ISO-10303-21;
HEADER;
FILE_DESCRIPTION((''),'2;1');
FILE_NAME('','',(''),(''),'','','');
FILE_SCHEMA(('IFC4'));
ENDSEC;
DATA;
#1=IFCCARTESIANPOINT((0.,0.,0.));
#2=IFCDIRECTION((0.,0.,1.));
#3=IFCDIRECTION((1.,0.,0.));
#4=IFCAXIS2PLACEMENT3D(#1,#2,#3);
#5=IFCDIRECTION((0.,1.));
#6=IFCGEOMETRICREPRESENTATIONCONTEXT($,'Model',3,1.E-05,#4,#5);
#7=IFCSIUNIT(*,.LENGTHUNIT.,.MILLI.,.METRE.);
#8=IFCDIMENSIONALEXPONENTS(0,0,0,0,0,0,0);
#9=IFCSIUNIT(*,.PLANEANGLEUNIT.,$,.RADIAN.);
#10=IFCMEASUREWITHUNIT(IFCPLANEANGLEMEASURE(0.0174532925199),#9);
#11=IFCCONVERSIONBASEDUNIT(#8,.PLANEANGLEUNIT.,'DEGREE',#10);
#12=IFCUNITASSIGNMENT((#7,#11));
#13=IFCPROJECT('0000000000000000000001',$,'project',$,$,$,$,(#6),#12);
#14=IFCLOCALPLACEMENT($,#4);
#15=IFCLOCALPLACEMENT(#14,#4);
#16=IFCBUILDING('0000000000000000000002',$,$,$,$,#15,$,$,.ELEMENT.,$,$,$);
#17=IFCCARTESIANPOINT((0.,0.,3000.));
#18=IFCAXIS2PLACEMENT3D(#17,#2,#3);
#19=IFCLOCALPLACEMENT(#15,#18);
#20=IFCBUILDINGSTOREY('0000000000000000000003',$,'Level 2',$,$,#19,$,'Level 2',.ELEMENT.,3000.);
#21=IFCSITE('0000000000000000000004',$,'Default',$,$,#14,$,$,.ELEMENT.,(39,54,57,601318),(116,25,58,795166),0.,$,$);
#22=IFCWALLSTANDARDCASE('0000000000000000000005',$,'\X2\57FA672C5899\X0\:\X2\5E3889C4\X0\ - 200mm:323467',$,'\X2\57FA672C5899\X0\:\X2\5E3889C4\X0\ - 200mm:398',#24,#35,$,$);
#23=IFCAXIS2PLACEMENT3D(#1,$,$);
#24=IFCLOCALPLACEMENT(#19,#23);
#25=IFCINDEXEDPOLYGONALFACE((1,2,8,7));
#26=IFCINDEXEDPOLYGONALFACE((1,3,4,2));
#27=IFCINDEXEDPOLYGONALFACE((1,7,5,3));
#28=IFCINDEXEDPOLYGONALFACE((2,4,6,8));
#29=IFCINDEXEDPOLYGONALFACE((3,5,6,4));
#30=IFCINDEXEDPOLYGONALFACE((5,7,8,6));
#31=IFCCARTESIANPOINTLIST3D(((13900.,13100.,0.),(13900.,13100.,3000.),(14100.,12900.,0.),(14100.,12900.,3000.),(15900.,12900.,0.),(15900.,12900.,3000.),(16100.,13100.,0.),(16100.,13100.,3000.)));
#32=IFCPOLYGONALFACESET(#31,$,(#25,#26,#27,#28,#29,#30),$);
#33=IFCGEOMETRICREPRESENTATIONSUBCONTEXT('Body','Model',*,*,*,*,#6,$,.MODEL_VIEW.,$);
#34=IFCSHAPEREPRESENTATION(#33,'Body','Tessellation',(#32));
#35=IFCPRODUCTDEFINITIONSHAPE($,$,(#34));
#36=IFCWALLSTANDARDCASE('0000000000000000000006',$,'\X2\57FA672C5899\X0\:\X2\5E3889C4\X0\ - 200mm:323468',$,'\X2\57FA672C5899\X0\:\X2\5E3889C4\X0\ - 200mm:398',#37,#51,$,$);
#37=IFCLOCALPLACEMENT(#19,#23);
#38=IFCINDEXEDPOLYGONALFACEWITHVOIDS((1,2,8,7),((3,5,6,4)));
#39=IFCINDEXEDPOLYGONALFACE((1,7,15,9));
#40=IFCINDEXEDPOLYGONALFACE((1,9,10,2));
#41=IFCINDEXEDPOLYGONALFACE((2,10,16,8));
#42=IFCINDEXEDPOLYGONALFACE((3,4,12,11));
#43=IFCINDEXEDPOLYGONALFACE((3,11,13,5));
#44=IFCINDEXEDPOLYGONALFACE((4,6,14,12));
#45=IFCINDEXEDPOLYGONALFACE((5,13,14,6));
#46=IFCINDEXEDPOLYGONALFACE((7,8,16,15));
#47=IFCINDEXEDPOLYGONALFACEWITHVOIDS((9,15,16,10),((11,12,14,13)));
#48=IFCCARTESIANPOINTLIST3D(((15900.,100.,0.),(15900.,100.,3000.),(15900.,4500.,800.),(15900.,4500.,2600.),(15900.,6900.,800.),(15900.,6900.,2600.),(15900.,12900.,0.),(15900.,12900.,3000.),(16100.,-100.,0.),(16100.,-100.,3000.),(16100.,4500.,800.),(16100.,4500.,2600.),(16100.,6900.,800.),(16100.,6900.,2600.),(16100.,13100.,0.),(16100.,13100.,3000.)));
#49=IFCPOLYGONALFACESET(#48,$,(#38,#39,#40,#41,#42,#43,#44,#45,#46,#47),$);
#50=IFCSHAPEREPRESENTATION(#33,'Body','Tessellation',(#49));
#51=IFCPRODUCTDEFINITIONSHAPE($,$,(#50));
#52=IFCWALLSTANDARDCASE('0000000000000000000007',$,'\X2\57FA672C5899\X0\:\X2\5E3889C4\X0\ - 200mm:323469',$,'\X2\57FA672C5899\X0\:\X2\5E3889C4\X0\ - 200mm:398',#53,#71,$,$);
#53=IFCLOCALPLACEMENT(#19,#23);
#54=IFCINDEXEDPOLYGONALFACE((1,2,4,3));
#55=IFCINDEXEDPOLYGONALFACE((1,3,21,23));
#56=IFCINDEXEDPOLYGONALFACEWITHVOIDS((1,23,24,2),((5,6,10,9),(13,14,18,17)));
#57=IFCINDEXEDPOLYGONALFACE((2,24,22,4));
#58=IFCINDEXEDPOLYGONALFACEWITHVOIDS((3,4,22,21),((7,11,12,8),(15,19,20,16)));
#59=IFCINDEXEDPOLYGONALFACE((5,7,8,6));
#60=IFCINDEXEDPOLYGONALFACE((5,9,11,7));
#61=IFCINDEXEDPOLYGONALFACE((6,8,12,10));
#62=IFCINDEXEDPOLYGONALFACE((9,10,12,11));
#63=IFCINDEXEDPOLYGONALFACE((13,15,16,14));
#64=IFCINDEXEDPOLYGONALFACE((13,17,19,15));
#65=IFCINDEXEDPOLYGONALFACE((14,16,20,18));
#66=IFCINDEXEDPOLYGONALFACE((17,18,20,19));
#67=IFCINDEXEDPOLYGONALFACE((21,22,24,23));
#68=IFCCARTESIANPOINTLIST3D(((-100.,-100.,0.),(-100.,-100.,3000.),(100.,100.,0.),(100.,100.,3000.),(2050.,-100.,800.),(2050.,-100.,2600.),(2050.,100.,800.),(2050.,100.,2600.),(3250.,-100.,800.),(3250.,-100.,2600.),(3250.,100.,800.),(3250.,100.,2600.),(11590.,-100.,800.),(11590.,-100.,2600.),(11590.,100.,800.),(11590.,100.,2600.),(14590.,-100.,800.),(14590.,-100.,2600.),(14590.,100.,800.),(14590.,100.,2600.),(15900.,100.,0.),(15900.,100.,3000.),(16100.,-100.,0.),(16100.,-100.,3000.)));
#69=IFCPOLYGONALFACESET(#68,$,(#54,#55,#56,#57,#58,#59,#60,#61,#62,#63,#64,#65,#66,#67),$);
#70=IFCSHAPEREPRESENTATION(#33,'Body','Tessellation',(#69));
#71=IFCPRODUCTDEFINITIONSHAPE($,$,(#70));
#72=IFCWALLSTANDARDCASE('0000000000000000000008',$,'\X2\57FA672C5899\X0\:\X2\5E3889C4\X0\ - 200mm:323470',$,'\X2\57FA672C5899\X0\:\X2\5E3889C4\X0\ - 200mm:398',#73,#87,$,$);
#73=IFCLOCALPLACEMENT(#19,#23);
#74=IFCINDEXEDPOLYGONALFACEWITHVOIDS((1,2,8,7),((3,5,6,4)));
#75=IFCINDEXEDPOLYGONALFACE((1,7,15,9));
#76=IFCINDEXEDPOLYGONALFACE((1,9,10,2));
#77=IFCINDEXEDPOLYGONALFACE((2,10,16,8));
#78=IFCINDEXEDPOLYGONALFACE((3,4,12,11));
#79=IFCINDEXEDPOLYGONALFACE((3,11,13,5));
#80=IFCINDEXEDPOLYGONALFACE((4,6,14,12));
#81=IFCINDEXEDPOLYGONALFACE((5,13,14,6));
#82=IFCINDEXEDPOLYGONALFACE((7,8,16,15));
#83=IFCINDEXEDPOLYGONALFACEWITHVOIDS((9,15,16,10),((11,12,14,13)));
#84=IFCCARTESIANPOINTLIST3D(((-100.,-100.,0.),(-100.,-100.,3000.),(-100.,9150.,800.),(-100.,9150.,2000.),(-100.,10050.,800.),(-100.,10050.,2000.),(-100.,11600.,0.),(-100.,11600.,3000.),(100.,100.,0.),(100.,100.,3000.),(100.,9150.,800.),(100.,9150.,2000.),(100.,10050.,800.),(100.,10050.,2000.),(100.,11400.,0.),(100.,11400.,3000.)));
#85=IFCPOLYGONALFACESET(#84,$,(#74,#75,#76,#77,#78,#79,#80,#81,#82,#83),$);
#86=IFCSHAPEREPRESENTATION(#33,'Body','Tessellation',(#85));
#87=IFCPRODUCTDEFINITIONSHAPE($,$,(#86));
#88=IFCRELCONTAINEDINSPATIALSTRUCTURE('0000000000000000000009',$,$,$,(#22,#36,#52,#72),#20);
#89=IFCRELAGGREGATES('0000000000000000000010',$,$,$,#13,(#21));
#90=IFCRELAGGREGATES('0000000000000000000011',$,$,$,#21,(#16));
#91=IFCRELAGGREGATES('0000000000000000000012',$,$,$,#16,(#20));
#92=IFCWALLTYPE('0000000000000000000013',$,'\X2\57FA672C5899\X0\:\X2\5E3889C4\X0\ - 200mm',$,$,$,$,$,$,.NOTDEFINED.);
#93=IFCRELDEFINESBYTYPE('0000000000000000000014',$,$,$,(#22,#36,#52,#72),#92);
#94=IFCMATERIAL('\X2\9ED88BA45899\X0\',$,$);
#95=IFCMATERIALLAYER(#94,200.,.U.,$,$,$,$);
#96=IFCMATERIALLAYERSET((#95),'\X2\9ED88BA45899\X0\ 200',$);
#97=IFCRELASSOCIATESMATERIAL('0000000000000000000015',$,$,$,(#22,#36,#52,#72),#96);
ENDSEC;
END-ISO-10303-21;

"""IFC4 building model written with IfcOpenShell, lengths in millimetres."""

from ifc_helpers import new_model, entity, si_unit, converted_unit, direction, frame, origin_with_axes, place, context, subcontext, project, spatial, polyline, outline, extrude, material, layer, layer_set, layer_usage, type_object, element, save


model = new_model("IFC4")

# Units and contexts
model_context = context("Model", 3, precision=1e-05, world=origin_with_axes(), true_north=direction((0.0, 1.0)))
body_context = subcontext(model_context, "Body", "Model", "MODEL_VIEW")
ifc_project = project(units=[si_unit("LENGTHUNIT", "METRE", prefix="MILLI"), converted_unit("PLANEANGLEUNIT", "DEGREE", entity("IfcPlaneAngleMeasure", 0.0174532925199), si_unit("PLANEANGLEUNIT", "RADIAN"), dimensions=[0, 0, 0, 0, 0, 0, 0])], contexts=[model_context])

# Site, building, storey
site_placement = place(None, origin_with_axes())
site = spatial("IfcSite", under=ifc_project, at=site_placement, Name="Default", CompositionType="ELEMENT", RefLatitude=(39, 54, 57, 601318), RefLongitude=(116, 25, 58, 795166), RefElevation=0.0)
building_placement = place(site_placement, origin_with_axes())
building = spatial("IfcBuilding", under=site, at=building_placement, CompositionType="ELEMENT")
storey_placement = place(building_placement, frame((0.0, 0.0, 3000.0), z_axis=(0.0, 0.0, 1.0), x_axis=(1.0, 0.0, 0.0)))
storey = spatial("IfcBuildingStorey", under=building, at=storey_placement, Name="Level 2", LongName="Level 2", CompositionType="ELEMENT", Elevation=3000.0)

# Shared definitions
ifc_material_1 = material(Name="默认墙")
ifc_layer_1 = layer(ifc_material_1, 200.0, ventilated="UNKNOWN")
ifc_layer_set_1 = layer_set([ifc_layer_1], Name="默认墙 200")
wall_type = type_object("IfcWallType", Name="基本墙:常规 - 200mm", PredefinedType="NOTDEFINED")

# Wall
ifc_layer_usage_1 = layer_usage(ifc_layer_set_1, "AXIS2", "POSITIVE", -100.0)
wall_1_placement = place(storey_placement, frame((14000.0, 13000.0, 0.0), z_axis=(0.0, 0.0, 1.0), x_axis=(1.0, 0.0, 0.0)))
element("IfcWallStandardCase", 1, at=wall_1_placement, inside=storey, type_object=wall_type, material=ifc_layer_usage_1, Name="基本墙:常规 - 200mm:323467", ObjectType="基本墙:常规 - 200mm:398", context=body_context, shape_type="SweptSolid", body=[
    extrude(outline(polyline([(100.0, -100.0), (1900.0, -100.0), (2100.0, 100.0), (-100.0, 100.0), (100.0, -100.0)])), origin_with_axes(), (0.0, 0.0, 1.0), 3000.0),
])

# Wall, opening
ifc_layer_usage_2 = layer_usage(ifc_layer_set_1, "AXIS2", "POSITIVE", -100.0)
wall_2_placement = place(storey_placement, frame((16000.0, 13000.0, 0.0), z_axis=(0.0, 0.0, 1.0), x_axis=(0.0, -1.0, 0.0)))
wall_2 = element("IfcWallStandardCase", 2, at=wall_2_placement, inside=storey, type_object=wall_type, material=ifc_layer_usage_2, Name="基本墙:常规 - 200mm:323468", ObjectType="基本墙:常规 - 200mm:398", context=body_context, shape_type="SweptSolid", body=[
    extrude(outline(polyline([(100.0, -100.0), (12900.0, -100.0), (13100.0, 100.0), (-100.0, 100.0), (100.0, -100.0)])), origin_with_axes(), (0.0, 0.0, 1.0), 3000.0),
])
opening_1_placement = place(wall_2_placement, frame((7300.0, 0.0, 800.0), z_axis=(0.0, 0.0, 1.0), x_axis=(1.0, 0.0, 0.0)))
element("IfcOpeningElement", 3, at=opening_1_placement, cuts=wall_2, context=body_context, shape_type="SweptSolid", body=[
    extrude(outline(polyline([(-1200.0, 0.0), (-1200.0, -1800.0), (1200.0, -1800.0), (1200.0, 0.0), (-1200.0, 0.0)])), frame((0.0, -100.0, 0.0), z_axis=(0.0, 1.0, 0.0), x_axis=(1.0, 0.0, 0.0)), (0.0, 0.0, 1.0), 200.0),
])

# Wall, openings
ifc_layer_usage_3 = layer_usage(ifc_layer_set_1, "AXIS2", "POSITIVE", -100.0)
wall_3_placement = place(storey_placement, frame((16000.0, 0.0, 0.0), z_axis=(0.0, 0.0, 1.0), x_axis=(-1.0, 0.0, 0.0)))
wall_3 = element("IfcWallStandardCase", 4, at=wall_3_placement, inside=storey, type_object=wall_type, material=ifc_layer_usage_3, Name="基本墙:常规 - 200mm:323469", ObjectType="基本墙:常规 - 200mm:398", context=body_context, shape_type="SweptSolid", body=[
    extrude(outline(polyline([(100.0, -100.0), (15900.0, -100.0), (16100.0, 100.0), (-100.0, 100.0), (100.0, -100.0)])), origin_with_axes(), (0.0, 0.0, 1.0), 3000.0),
])
opening_2_placement = place(wall_3_placement, frame((13350.0, 0.0, 800.0), z_axis=(0.0, 0.0, 1.0), x_axis=(1.0, 0.0, 0.0)))
element("IfcOpeningElement", 5, at=opening_2_placement, cuts=wall_3, context=body_context, shape_type="SweptSolid", body=[
    extrude(outline(polyline([(-600.0, 0.0), (-600.0, -1800.0), (600.0, -1800.0), (600.0, 0.0), (-600.0, 0.0)])), frame((0.0, -100.0, 0.0), z_axis=(0.0, 1.0, 0.0), x_axis=(1.0, 0.0, 0.0)), (0.0, 0.0, 1.0), 200.0),
])
opening_3_placement = place(wall_3_placement, frame((2910.0, 0.0, 800.0), z_axis=(0.0, 0.0, 1.0), x_axis=(1.0, 0.0, 0.0)))
element("IfcOpeningElement", 6, at=opening_3_placement, cuts=wall_3, context=body_context, shape_type="SweptSolid", body=[
    extrude(outline(polyline([(-1500.0, 0.0), (-1500.0, -1800.0), (1500.0, -1800.0), (1500.0, 0.0), (-1500.0, 0.0)])), frame((0.0, -100.0, 0.0), z_axis=(0.0, 1.0, 0.0), x_axis=(1.0, 0.0, 0.0)), (0.0, 0.0, 1.0), 200.0),
])

# Wall, opening
ifc_layer_usage_4 = layer_usage(ifc_layer_set_1, "AXIS2", "POSITIVE", -100.0)
wall_4_placement = place(storey_placement, frame((0.0, 0.0, 0.0), z_axis=(0.0, 0.0, 1.0), x_axis=(0.0, 1.0, 0.0)))
wall_4 = element("IfcWallStandardCase", 7, at=wall_4_placement, inside=storey, type_object=wall_type, material=ifc_layer_usage_4, Name="基本墙:常规 - 200mm:323470", ObjectType="基本墙:常规 - 200mm:398", context=body_context, shape_type="SweptSolid", body=[
    extrude(outline(polyline([(100.0, -100.0), (11400.0, -100.0), (11600.0, 100.0), (-100.0, 100.0), (100.0, -100.0)])), origin_with_axes(), (0.0, 0.0, 1.0), 3000.0),
])
opening_4_placement = place(wall_4_placement, frame((9600.0, 0.0, 800.0), z_axis=(0.0, 0.0, 1.0), x_axis=(1.0, 0.0, 0.0)))
element("IfcOpeningElement", 8, at=opening_4_placement, cuts=wall_4, context=body_context, shape_type="SweptSolid", body=[
    extrude(outline(polyline([(450.0, -1200.0), (450.0, 0.0), (-450.0, 0.0), (-450.0, -1200.0), (450.0, -1200.0)])), frame((0.0, 100.0, 0.0), z_axis=(0.0, -1.0, 0.0), x_axis=(-1.0, 0.0, 0.0)), (0.0, 0.0, 1.0), 200.0),
])

save(model, "model.ifc")
